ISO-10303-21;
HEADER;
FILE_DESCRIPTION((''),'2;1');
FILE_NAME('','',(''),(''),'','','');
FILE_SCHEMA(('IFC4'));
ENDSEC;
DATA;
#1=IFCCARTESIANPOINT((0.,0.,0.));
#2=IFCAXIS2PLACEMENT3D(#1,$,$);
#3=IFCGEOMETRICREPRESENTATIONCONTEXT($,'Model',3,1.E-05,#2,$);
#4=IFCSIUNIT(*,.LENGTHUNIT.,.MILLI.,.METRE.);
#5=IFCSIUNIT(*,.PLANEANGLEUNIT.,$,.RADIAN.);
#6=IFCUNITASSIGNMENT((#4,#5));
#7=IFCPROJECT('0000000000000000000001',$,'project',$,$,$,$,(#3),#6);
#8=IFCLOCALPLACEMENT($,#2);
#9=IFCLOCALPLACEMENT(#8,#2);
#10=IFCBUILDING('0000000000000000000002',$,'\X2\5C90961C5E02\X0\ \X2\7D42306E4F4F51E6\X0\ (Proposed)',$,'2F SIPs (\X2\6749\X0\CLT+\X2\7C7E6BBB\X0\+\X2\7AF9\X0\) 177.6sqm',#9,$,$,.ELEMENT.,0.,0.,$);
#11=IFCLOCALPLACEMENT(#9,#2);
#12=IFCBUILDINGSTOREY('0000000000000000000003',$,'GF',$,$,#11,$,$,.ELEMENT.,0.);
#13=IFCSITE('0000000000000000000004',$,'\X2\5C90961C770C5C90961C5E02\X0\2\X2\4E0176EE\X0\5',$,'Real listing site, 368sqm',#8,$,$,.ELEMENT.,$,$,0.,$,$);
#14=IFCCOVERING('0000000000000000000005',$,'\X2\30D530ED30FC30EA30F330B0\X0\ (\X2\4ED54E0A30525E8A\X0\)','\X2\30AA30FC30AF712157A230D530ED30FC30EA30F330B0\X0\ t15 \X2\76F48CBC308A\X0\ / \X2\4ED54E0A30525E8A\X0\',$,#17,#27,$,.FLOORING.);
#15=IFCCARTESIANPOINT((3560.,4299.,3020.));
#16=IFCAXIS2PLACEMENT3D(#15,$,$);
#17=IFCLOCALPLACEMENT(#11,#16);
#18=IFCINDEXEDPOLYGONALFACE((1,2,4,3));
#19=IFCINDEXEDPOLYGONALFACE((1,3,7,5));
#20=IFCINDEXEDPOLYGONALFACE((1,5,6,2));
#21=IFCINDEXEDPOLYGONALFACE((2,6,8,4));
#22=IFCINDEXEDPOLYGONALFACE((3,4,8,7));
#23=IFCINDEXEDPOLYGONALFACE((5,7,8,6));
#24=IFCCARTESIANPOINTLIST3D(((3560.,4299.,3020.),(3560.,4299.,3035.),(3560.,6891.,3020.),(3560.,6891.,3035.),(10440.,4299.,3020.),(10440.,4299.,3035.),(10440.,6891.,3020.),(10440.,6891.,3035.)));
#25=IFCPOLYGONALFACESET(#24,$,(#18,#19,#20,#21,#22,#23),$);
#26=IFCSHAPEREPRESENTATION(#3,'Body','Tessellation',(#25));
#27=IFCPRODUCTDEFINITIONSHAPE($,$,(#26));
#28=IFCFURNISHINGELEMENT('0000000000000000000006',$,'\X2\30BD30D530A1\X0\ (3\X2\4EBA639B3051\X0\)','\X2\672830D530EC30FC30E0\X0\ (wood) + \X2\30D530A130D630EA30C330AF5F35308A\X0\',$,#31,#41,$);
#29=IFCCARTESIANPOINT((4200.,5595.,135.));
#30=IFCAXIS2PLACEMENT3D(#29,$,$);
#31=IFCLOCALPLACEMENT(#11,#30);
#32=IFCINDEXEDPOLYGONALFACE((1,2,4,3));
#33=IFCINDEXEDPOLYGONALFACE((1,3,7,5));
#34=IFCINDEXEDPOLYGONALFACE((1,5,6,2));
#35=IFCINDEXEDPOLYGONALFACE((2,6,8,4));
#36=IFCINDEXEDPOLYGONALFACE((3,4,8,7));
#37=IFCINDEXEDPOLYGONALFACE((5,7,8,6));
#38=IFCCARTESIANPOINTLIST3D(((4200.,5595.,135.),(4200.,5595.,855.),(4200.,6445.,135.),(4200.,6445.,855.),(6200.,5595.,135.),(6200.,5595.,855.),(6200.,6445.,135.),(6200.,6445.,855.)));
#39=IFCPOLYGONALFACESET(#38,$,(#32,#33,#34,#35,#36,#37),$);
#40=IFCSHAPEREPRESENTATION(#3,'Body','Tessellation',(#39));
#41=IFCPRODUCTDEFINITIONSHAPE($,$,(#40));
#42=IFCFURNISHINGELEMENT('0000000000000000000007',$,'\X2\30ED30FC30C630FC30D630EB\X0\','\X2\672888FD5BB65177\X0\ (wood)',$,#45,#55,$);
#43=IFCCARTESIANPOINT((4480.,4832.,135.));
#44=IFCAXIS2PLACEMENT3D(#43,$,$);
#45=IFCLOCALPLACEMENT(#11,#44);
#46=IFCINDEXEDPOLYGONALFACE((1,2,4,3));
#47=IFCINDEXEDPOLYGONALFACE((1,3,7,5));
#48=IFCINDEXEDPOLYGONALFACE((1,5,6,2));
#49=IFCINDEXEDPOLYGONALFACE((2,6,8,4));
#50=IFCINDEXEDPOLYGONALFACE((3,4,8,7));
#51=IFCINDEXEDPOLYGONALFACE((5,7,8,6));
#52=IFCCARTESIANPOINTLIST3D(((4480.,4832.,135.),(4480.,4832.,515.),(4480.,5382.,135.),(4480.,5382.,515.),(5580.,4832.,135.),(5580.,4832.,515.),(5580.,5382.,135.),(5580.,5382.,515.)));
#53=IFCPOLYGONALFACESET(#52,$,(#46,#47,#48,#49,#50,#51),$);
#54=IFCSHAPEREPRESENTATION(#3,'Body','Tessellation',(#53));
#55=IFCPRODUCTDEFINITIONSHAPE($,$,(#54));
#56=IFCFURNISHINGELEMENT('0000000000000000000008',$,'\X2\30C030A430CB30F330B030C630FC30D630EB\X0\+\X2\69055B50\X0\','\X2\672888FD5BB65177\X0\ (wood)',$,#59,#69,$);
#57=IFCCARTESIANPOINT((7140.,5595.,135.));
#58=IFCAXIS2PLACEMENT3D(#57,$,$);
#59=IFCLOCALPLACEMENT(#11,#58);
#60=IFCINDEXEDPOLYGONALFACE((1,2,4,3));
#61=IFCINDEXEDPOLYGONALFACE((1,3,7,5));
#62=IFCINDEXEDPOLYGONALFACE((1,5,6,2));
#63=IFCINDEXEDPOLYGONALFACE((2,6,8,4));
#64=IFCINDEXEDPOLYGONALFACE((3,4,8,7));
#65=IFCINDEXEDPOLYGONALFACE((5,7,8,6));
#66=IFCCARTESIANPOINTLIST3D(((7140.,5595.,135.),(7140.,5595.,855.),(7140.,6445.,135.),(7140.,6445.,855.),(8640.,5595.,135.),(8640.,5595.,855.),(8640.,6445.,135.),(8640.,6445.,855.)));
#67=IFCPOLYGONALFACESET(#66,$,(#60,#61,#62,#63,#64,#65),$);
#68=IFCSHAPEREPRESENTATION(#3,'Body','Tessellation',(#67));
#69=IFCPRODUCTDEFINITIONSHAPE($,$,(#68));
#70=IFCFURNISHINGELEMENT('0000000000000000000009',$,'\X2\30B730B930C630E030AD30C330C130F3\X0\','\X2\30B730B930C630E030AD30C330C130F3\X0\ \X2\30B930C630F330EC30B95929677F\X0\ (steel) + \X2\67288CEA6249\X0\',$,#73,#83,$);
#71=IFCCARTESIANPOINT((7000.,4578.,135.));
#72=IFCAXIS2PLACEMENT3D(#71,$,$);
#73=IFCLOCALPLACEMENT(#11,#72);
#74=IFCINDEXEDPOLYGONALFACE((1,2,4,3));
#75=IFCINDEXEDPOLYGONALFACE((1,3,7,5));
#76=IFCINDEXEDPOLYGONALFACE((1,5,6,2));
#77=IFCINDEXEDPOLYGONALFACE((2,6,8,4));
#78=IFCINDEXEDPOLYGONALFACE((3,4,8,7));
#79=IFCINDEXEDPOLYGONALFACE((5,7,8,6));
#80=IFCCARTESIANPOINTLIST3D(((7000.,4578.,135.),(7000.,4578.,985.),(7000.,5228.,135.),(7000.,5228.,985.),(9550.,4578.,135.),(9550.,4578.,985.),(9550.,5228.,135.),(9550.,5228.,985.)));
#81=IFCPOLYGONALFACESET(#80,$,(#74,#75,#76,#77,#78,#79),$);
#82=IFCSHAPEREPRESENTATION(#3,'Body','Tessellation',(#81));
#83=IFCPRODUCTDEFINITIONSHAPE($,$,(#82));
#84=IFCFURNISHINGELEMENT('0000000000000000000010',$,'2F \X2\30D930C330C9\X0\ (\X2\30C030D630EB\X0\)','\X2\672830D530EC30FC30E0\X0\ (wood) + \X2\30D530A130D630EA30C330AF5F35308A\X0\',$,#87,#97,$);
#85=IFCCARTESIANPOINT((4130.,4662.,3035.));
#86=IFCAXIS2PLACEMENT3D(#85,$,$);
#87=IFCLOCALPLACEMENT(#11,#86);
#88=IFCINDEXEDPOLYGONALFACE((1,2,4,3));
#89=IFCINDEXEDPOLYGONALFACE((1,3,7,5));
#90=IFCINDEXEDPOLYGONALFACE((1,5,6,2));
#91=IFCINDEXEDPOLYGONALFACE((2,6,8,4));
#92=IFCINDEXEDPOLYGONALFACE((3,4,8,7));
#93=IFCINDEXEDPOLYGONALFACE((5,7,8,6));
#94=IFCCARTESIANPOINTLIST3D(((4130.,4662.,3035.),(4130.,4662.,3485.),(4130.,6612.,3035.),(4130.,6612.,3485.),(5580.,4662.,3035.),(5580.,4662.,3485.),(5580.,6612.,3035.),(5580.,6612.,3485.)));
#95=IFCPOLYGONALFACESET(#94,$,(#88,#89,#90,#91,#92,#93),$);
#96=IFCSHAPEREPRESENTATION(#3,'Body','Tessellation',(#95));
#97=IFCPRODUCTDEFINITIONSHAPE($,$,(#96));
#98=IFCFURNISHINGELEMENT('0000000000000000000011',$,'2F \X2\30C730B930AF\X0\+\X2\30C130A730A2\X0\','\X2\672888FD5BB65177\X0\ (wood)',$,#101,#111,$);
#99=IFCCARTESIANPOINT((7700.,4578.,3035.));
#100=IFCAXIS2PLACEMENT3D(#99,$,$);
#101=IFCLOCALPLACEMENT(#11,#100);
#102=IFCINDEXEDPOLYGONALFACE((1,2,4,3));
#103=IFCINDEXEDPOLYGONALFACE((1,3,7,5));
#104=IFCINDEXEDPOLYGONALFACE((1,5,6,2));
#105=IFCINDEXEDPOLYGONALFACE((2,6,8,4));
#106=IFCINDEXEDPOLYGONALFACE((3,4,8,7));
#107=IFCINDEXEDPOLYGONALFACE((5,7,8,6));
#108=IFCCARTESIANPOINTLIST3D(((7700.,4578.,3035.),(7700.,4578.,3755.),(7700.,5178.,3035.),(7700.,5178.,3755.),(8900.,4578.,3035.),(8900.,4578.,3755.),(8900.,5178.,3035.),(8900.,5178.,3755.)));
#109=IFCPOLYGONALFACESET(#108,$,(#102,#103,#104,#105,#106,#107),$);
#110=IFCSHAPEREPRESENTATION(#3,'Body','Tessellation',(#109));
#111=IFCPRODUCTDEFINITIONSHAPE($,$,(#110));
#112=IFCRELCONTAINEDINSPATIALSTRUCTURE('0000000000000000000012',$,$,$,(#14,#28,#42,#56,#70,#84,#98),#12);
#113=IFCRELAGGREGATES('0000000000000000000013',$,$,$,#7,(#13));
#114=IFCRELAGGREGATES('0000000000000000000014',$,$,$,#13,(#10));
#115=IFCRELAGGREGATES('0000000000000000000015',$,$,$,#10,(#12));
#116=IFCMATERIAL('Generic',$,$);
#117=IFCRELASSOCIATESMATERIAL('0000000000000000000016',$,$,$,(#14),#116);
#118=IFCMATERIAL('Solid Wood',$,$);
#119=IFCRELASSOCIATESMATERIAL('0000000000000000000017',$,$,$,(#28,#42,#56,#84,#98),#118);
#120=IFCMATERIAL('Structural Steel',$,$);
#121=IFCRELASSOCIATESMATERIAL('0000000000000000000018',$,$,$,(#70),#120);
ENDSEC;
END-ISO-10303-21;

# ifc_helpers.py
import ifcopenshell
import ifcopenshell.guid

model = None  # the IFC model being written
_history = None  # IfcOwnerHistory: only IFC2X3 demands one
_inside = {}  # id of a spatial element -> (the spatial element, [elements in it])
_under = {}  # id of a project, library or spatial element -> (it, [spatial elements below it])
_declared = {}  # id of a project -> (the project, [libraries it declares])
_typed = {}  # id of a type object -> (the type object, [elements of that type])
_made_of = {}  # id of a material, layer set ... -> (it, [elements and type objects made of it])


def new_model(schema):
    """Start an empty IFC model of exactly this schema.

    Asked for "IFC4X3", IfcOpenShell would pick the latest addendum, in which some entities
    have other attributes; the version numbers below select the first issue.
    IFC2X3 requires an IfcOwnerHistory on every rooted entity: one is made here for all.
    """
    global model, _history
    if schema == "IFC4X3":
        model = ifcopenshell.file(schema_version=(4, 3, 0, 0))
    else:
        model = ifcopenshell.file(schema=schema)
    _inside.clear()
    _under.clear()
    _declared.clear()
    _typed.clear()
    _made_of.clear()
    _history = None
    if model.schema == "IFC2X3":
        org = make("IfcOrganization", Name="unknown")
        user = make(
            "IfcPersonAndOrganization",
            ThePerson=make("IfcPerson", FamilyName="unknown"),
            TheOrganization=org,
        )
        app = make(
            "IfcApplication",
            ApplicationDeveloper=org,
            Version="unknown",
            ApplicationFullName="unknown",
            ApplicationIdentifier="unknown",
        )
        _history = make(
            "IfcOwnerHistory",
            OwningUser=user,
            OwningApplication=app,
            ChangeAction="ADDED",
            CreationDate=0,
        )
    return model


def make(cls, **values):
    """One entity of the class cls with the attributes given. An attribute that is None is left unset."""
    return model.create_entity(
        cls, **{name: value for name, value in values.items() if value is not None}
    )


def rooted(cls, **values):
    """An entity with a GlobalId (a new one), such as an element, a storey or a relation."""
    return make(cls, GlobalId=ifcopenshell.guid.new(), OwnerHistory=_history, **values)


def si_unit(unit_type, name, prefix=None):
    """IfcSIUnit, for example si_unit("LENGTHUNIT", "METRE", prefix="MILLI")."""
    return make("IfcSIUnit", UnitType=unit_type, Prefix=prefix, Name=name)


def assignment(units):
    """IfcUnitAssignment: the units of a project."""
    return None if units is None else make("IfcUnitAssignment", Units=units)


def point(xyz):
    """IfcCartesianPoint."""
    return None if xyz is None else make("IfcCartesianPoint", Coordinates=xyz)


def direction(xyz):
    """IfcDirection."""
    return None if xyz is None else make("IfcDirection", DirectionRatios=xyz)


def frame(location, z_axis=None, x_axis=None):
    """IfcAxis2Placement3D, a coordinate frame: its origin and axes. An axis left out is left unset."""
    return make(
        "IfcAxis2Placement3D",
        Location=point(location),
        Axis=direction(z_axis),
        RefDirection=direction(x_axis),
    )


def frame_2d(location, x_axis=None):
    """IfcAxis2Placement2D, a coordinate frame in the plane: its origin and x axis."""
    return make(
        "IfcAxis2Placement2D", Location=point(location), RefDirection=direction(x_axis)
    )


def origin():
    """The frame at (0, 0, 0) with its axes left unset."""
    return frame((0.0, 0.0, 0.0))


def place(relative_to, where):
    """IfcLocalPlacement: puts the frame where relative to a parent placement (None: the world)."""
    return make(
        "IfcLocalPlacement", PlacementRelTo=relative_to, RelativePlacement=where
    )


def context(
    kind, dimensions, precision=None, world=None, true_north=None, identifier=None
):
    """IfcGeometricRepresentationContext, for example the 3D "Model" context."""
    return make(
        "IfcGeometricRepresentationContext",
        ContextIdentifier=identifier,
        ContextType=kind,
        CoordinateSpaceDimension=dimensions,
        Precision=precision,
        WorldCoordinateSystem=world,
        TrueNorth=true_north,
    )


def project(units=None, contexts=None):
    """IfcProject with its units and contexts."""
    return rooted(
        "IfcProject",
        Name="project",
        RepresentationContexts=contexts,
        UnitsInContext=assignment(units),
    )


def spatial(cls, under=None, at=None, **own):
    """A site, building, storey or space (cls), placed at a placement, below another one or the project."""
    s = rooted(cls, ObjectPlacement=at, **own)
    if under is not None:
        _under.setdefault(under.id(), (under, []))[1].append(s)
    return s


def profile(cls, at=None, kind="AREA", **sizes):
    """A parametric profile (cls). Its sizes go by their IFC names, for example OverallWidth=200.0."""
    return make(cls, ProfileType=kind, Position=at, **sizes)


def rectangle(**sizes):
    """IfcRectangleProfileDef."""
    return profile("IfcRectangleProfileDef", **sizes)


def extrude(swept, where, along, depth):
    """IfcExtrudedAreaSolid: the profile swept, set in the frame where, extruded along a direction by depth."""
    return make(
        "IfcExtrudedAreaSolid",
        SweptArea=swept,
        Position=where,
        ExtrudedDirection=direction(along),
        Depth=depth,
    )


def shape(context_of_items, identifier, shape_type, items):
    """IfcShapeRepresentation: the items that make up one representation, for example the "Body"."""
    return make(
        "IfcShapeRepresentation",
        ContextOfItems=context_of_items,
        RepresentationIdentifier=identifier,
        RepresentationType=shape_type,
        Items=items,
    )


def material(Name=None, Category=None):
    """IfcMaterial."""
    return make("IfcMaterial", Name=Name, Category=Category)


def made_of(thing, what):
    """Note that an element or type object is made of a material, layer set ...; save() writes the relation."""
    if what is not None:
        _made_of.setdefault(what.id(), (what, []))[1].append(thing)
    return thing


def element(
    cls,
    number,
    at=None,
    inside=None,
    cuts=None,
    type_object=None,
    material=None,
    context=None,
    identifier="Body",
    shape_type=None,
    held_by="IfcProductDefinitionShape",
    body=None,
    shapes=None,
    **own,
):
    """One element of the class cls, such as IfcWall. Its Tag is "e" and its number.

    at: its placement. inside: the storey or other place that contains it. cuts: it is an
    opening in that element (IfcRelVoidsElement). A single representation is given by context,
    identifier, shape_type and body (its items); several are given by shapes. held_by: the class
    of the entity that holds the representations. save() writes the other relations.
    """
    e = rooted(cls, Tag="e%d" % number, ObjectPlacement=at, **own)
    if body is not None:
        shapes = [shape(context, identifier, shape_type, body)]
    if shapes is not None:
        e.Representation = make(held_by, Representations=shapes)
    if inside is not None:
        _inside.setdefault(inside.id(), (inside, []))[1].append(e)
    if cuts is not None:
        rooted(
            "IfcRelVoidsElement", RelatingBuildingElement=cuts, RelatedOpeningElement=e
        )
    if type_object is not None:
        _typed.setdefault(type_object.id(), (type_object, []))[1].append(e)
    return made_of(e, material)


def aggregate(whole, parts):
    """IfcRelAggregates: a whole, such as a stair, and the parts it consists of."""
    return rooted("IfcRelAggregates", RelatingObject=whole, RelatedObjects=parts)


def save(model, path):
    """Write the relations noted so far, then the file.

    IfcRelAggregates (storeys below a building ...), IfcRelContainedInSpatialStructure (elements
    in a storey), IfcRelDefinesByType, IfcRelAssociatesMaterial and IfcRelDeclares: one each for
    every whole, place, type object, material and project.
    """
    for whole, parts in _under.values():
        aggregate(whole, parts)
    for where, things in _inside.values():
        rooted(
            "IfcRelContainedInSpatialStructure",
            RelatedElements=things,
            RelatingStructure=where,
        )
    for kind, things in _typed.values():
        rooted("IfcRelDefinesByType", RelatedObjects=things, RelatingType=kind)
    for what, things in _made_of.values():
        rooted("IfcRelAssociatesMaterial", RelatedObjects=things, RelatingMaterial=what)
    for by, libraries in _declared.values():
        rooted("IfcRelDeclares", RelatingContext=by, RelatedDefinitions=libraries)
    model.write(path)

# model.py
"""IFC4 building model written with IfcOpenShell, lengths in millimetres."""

from ifc_helpers import new_model, si_unit, frame, frame_2d, origin, place, context, project, spatial, rectangle, extrude, material, element, save


model = new_model("IFC4")

# Units and contexts
model_context = context("Model", 3, precision=1e-05, world=origin())
ifc_project = project(units=[si_unit("LENGTHUNIT", "METRE", prefix="MILLI"), si_unit("PLANEANGLEUNIT", "RADIAN")], contexts=[model_context])

# Site, building, storey
site_placement = place(None, origin())
site = spatial("IfcSite", under=ifc_project, at=site_placement, Name="岐阜県岐阜市2丁目5", ObjectType="Real listing site, 368sqm", CompositionType="ELEMENT", RefElevation=0.0)
building_placement = place(site_placement, origin())
building = spatial("IfcBuilding", under=site, at=building_placement, Name="岐阜市 終の住処 (Proposed)", ObjectType="2F SIPs (杉CLT+籾殻+竹) 177.6sqm", CompositionType="ELEMENT", ElevationOfRefHeight=0.0, ElevationOfTerrain=0.0)
storey_placement = place(building_placement, origin())
storey = spatial("IfcBuildingStorey", under=building, at=storey_placement, Name="GF", CompositionType="ELEMENT", Elevation=0.0)

# Shared definitions
ifc_material_1 = material(Name="Solid Wood")

# Shared definitions
ifc_material_2 = material(Name="Generic")

# Shared definitions
ifc_material_3 = material(Name="Structural Steel")

# Covering
covering_placement = place(storey_placement, frame((3560.0, 4299.0, 3020.0)))
element("IfcCovering", 1, at=covering_placement, inside=storey, material=ifc_material_2, Name="フローリング (仕上げ床)", Description="オーク無垢フローリング t15 直貼り / 仕上げ床", PredefinedType="FLOORING", context=model_context, shape_type="SweptSolid", body=[
    extrude(rectangle(XDim=6880.0, YDim=2592.0, at=frame_2d((3440.0, 1296.0))), frame((3560.0, 4299.0, 3020.0)), (0.0, 0.0, 1.0), 15.0),
])

# Furnishing elements
furnishing_1_placement = place(storey_placement, frame((4200.0, 5595.0, 135.0)))
element("IfcFurnishingElement", 2, at=furnishing_1_placement, inside=storey, material=ifc_material_1, Name="ソファ (3人掛け)", Description="木フレーム (wood) + ファブリック張り", context=model_context, shape_type="SweptSolid", body=[
    extrude(rectangle(XDim=2000.0, YDim=850.0, at=frame_2d((1000.0, 425.0))), frame((4200.0, 5595.0, 135.0)), (0.0, 0.0, 1.0), 720.0),
])
furnishing_2_placement = place(storey_placement, frame((4480.0, 4832.0, 135.0)))
element("IfcFurnishingElement", 3, at=furnishing_2_placement, inside=storey, material=ifc_material_1, Name="ローテーブル", Description="木製家具 (wood)", context=model_context, shape_type="SweptSolid", body=[
    extrude(rectangle(XDim=1100.0, YDim=550.0, at=frame_2d((550.0, 275.0))), frame((4480.0, 4832.0, 135.0)), (0.0, 0.0, 1.0), 380.0),
])
furnishing_3_placement = place(storey_placement, frame((7140.0, 5595.0, 135.0)))
element("IfcFurnishingElement", 4, at=furnishing_3_placement, inside=storey, material=ifc_material_1, Name="ダイニングテーブル+椅子", Description="木製家具 (wood)", context=model_context, shape_type="SweptSolid", body=[
    extrude(rectangle(XDim=1500.0, YDim=850.0, at=frame_2d((750.0, 425.0))), frame((7140.0, 5595.0, 135.0)), (0.0, 0.0, 1.0), 720.0),
])
furnishing_4_placement = place(storey_placement, frame((7000.0, 4578.0, 135.0)))
element("IfcFurnishingElement", 5, at=furnishing_4_placement, inside=storey, material=ifc_material_3, Name="システムキッチン", Description="システムキッチン ステンレス天板 (steel) + 木質扉", context=model_context, shape_type="SweptSolid", body=[
    extrude(rectangle(XDim=2550.0, YDim=650.0, at=frame_2d((1275.0, 325.0))), frame((7000.0, 4578.0, 135.0)), (0.0, 0.0, 1.0), 850.0),
])
furnishing_5_placement = place(storey_placement, frame((4130.0, 4662.0, 3035.0)))
element("IfcFurnishingElement", 6, at=furnishing_5_placement, inside=storey, material=ifc_material_1, Name="2F ベッド (ダブル)", Description="木フレーム (wood) + ファブリック張り", context=model_context, shape_type="SweptSolid", body=[
    extrude(rectangle(XDim=1450.0, YDim=1950.0, at=frame_2d((725.0, 975.0))), frame((4130.0, 4662.0, 3035.0)), (0.0, 0.0, 1.0), 450.0),
])
furnishing_6_placement = place(storey_placement, frame((7700.0, 4578.0, 3035.0)))
element("IfcFurnishingElement", 7, at=furnishing_6_placement, inside=storey, material=ifc_material_1, Name="2F デスク+チェア", Description="木製家具 (wood)", context=model_context, shape_type="SweptSolid", body=[
    extrude(rectangle(XDim=1200.0, YDim=600.0, at=frame_2d((600.0, 300.0))), frame((7700.0, 4578.0, 3035.0)), (0.0, 0.0, 1.0), 720.0),
])

save(model, "model.ifc")
